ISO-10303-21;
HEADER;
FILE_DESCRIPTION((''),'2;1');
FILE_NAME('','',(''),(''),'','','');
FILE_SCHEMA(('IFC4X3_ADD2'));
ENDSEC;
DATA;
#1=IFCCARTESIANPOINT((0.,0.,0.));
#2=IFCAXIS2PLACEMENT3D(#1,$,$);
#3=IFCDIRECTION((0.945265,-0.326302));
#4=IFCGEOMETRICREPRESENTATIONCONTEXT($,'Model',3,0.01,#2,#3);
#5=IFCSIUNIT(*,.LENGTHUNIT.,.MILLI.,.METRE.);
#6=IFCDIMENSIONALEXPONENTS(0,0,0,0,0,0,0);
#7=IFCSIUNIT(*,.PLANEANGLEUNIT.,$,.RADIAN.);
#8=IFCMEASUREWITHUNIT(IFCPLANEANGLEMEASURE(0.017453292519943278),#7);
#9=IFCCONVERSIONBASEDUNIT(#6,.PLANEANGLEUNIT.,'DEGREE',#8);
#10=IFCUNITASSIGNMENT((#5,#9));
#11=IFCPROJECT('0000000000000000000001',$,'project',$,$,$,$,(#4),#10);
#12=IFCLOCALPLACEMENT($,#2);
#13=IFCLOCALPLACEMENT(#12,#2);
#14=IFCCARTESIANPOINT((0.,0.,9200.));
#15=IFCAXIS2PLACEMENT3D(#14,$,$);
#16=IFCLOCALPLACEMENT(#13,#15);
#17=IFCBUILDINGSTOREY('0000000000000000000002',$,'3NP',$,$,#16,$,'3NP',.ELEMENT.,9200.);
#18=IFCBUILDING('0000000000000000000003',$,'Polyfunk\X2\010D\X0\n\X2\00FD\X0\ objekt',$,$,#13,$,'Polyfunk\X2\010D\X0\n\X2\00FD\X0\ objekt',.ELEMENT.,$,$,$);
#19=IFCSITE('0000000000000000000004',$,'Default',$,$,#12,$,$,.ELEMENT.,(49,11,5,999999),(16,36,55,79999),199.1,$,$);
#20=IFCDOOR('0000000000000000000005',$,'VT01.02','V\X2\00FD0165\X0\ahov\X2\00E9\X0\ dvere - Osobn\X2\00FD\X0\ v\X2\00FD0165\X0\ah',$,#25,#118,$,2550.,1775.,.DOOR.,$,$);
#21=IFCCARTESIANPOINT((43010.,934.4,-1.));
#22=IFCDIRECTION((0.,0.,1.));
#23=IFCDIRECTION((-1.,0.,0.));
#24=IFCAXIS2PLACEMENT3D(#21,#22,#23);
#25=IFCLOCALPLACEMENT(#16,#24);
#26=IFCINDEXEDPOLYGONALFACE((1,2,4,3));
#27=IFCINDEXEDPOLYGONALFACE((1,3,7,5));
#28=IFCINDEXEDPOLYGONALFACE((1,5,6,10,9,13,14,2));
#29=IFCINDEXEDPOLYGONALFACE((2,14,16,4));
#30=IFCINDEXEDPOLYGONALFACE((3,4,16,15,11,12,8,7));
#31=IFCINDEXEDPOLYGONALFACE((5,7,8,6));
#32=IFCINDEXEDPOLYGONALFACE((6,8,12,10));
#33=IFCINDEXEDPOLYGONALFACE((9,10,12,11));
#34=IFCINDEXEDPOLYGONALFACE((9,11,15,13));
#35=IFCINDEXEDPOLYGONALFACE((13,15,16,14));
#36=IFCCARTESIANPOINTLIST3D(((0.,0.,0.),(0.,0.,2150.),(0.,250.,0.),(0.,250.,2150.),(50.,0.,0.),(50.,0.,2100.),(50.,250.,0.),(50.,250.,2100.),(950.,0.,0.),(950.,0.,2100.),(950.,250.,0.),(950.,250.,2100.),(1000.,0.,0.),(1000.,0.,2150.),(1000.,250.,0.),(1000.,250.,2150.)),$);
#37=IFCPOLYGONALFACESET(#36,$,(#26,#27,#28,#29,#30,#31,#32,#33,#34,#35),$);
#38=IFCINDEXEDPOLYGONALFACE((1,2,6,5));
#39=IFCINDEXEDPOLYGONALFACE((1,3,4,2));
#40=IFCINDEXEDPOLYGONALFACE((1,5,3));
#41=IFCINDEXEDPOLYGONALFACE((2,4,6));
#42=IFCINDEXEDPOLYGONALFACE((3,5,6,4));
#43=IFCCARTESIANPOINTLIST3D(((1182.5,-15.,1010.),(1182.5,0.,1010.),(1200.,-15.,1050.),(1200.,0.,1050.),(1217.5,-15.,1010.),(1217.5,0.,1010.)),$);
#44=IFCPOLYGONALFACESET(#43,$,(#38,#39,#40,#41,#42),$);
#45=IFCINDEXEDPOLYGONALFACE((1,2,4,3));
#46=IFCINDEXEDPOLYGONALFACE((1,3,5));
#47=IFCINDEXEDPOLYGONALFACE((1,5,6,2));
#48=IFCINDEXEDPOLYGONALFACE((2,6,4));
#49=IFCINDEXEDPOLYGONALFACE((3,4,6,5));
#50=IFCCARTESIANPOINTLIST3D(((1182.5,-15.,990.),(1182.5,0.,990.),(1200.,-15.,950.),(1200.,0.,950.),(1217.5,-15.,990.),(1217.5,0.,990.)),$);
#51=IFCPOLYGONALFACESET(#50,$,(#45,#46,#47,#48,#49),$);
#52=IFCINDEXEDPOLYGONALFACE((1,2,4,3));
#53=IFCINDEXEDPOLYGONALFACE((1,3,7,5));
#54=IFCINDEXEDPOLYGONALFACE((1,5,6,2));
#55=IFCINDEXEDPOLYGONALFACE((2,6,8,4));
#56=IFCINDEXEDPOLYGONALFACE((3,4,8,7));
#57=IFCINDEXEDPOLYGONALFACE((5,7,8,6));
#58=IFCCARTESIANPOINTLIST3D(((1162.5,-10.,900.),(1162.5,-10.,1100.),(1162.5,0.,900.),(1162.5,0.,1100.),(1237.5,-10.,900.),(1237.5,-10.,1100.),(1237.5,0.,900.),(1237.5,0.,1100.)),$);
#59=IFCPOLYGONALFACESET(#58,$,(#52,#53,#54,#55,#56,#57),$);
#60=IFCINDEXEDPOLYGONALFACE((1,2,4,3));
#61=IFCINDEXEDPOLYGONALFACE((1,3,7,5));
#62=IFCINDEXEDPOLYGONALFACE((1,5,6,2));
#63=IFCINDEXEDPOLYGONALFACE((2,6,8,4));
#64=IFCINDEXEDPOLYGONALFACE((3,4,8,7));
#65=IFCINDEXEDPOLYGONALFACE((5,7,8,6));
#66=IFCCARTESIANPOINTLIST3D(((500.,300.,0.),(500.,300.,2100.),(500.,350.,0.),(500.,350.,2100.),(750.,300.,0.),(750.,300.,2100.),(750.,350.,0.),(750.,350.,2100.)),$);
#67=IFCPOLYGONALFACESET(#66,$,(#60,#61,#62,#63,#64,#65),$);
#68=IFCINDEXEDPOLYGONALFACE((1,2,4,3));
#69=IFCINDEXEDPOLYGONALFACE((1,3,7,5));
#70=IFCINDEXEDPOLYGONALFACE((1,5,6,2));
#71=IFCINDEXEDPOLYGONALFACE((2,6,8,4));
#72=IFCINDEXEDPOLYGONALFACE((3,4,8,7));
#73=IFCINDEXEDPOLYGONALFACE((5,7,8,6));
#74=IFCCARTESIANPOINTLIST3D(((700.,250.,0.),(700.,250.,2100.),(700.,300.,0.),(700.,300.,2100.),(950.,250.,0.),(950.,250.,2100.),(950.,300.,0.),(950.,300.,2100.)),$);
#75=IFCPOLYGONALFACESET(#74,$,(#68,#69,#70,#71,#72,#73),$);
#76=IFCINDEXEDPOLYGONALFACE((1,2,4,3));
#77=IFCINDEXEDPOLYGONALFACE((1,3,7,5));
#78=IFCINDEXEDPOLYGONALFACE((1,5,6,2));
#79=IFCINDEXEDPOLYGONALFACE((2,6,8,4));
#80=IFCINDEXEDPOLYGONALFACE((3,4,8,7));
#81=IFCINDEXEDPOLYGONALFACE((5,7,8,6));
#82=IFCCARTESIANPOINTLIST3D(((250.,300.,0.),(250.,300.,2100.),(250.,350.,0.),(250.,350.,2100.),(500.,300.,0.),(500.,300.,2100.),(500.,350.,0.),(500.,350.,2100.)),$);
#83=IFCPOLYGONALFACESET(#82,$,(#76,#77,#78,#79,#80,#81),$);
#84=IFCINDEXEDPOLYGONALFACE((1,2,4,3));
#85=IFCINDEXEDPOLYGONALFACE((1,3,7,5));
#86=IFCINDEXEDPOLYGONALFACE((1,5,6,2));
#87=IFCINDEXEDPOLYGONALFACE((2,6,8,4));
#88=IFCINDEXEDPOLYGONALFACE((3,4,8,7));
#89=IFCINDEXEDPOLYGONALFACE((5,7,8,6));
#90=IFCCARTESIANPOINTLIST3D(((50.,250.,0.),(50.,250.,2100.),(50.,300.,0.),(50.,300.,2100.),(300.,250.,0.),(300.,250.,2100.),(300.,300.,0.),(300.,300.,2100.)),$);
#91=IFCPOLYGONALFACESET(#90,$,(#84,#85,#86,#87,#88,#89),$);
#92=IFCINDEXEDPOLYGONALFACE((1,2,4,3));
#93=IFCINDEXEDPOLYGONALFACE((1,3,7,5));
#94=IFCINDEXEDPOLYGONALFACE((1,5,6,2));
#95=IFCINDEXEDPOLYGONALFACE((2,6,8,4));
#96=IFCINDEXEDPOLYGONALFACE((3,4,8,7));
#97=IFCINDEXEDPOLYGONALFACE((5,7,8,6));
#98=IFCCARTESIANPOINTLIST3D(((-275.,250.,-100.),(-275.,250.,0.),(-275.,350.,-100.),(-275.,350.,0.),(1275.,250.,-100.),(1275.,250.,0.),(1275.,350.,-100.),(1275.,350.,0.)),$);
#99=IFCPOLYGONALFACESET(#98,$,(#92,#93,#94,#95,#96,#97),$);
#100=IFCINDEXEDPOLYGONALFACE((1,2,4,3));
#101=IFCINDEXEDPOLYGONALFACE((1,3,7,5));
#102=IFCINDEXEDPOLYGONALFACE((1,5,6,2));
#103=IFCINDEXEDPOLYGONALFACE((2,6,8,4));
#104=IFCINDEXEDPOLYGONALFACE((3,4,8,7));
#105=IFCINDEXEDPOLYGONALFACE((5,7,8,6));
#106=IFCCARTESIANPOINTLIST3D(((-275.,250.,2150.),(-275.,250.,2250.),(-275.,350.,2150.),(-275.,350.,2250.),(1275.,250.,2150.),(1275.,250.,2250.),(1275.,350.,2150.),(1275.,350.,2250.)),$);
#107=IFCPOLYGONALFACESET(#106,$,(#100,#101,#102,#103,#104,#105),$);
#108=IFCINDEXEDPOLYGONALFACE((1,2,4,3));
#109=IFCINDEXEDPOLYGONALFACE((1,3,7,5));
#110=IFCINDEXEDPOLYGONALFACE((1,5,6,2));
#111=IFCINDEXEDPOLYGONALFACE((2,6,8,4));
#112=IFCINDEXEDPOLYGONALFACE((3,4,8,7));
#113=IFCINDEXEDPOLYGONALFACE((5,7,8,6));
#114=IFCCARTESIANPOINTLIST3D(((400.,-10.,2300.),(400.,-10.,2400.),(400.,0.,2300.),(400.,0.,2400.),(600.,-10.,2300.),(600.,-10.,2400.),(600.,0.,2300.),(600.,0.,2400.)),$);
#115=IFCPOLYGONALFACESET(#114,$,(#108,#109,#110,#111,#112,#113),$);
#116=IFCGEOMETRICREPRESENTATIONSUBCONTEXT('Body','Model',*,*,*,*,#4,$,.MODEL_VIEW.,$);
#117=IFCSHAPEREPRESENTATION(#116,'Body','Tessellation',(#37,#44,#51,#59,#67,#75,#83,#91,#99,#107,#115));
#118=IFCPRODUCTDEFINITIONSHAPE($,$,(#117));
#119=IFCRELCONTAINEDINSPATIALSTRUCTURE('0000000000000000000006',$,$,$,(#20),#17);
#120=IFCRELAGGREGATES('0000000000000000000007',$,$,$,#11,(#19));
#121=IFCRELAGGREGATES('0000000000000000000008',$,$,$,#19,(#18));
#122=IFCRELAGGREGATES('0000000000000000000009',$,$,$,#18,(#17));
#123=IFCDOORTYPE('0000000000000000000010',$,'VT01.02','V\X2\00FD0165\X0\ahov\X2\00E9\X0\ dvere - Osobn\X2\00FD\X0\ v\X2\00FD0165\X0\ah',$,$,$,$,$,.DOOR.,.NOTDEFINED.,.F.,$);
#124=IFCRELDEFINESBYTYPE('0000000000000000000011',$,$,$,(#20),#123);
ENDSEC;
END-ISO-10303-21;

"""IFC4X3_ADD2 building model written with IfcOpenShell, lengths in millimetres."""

from ifc_helpers import new_model, entity, si_unit, converted_unit, direction, frame, frame_2d, origin, origin_2d_with_axis, place, context, subcontext, project, spatial, polyline, rectangle, outline, extrude, source, transform, mapped, type_object, type_shapes, element, save


model = new_model("IFC4X3_ADD2")

# Units and contexts
model_context = context("Model", 3, precision=0.01, world=origin(), true_north=direction((0.945265, -0.326302)))
body_context = subcontext(model_context, "Body", "Model", "MODEL_VIEW")
ifc_project = project(units=[si_unit("LENGTHUNIT", "METRE", prefix="MILLI"), converted_unit("PLANEANGLEUNIT", "DEGREE", entity("IfcPlaneAngleMeasure", 0.017453292519943278), si_unit("PLANEANGLEUNIT", "RADIAN"), dimensions=[0, 0, 0, 0, 0, 0, 0])], contexts=[model_context])

# Site, building, storey
site_placement = place(None, origin())
site = spatial("IfcSite", under=ifc_project, at=site_placement, Name="Default", CompositionType="ELEMENT", RefLatitude=(49, 11, 5, 999999), RefLongitude=(16, 36, 55, 79999), RefElevation=199.1)
building_placement = place(site_placement, origin())
building = spatial("IfcBuilding", under=site, at=building_placement, Name="Polyfunkčný objekt", LongName="Polyfunkčný objekt", CompositionType="ELEMENT")
storey_placement = place(building_placement, frame((0.0, 0.0, 9200.0)))
storey = spatial("IfcBuildingStorey", under=building, at=storey_placement, Name="3NP", LongName="3NP", CompositionType="ELEMENT", Elevation=9200.0)

# Door
door_type = type_object("IfcDoorType", Name="VT01.02", Description="Výťahové dvere - Osobný výťah", OperationType="NOTDEFINED", ParameterTakesPrecedence=False, PredefinedType="DOOR")
shared_shape_1 = source(origin(), body_context, "Body", "SweptSolid", [
    extrude(outline(polyline([(-1087.5, -500.0), (1062.5, -500.0), (1062.5, -450.0), (-1037.5, -450.0), (-1037.5, 450.0), (1062.5, 450.0), (1062.5, 500.0), (-1087.5, 500.0), (-1087.5, -500.0)])), frame((500.0, 0.0, 1062.5), z_axis=(0.0, 1.0, 0.0), x_axis=(0.0, 0.0, -1.0)), (0.0, 0.0, 1.0), 250.0),
    extrude(outline(polyline([(-24.4, -10.7), (19.2, -10.7), (5.2, 21.4), (-24.4, -10.7)])), frame((1200.0, -15.0, 1023.3), z_axis=(0.0, 1.0, 0.0), x_axis=(0.400819, 0.0, -0.916157)), (0.0, 0.0, 1.0), 15.0),
    extrude(outline(polyline([(-24.4, -10.7), (19.2, -10.7), (5.2, 21.4), (-24.4, -10.7)])), frame((1200.0, -15.0, 976.7), z_axis=(0.0, 1.0, 0.0), x_axis=(-0.400819, 0.0, 0.916157)), (0.0, 0.0, 1.0), 15.0),
    extrude(rectangle(XDim=10.0, YDim=75.0, at=frame_2d((0.0, 0.0), x_axis=(1.0, 0.0))), frame((1200.0, -5.0, 900.0), z_axis=(0.0, 0.0, 1.0), x_axis=(0.0, 1.0, 0.0)), (0.0, 0.0, 1.0), 200.0),
    extrude(rectangle(XDim=50.0, YDim=250.0, at=origin_2d_with_axis()), frame((625.0, 325.0, 0.0), z_axis=(0.0, 0.0, 1.0), x_axis=(0.0, -1.0, 0.0)), (0.0, 0.0, 1.0), 2100.0),
    extrude(rectangle(XDim=50.0, YDim=250.0, at=frame_2d((0.0, 0.0), x_axis=(1.0, 0.0))), frame((825.0, 275.0, 0.0), z_axis=(0.0, 0.0, 1.0), x_axis=(0.0, -1.0, 0.0)), (0.0, 0.0, 1.0), 2100.0),
    extrude(rectangle(XDim=250.0, YDim=50.0, at=frame_2d((0.0, 0.0), x_axis=(1.0, 0.0))), frame((375.0, 325.0, 0.0), z_axis=(0.0, 0.0, 1.0), x_axis=(-1.0, 0.0, 0.0)), (0.0, 0.0, 1.0), 2100.0),
    extrude(rectangle(XDim=250.0, YDim=50.0, at=frame_2d((0.0, 0.0), x_axis=(1.0, 0.0))), frame((175.0, 275.0, 0.0), z_axis=(0.0, 0.0, 1.0), x_axis=(-1.0, 0.0, 0.0)), (0.0, 0.0, 1.0), 2100.0),
    extrude(rectangle(XDim=1550.0, YDim=100.0, at=frame_2d((0.0, 0.0), x_axis=(1.0, 0.0))), frame((500.0, 300.0, -100.0), z_axis=(0.0, 0.0, 1.0), x_axis=(-1.0, 0.0, 0.0)), (0.0, 0.0, 1.0), 100.0),
    extrude(rectangle(XDim=1550.0, YDim=100.0, at=frame_2d((0.0, 0.0), x_axis=(1.0, 0.0))), frame((500.0, 300.0, 2150.0), z_axis=(0.0, 0.0, 1.0), x_axis=(-1.0, 0.0, 0.0)), (0.0, 0.0, 1.0), 100.0),
    extrude(rectangle(XDim=10.0, YDim=200.0, at=frame_2d((0.0, 0.0), x_axis=(1.0, 0.0))), frame((500.0, -5.0, 2300.0), z_axis=(0.0, 0.0, 1.0), x_axis=(0.0, 1.0, 0.0)), (0.0, 0.0, 1.0), 100.0),
])
type_shapes(door_type, [shared_shape_1])
door_placement = place(storey_placement, frame((43010.0, 934.4, -1.0), z_axis=(0.0, 0.0, 1.0), x_axis=(-1.0, 0.0, 0.0)))
element("IfcDoor", 1, at=door_placement, inside=storey, type_object=door_type, Name="VT01.02", Description="Výťahové dvere - Osobný výťah", OverallHeight=2550.0, OverallWidth=1775.0, PredefinedType="DOOR", context=body_context, shape_type="MappedRepresentation", body=[
    mapped(shared_shape_1, transform((0.0, 0.0, 0.0), scale=1.0)),
])

save(model, "model.ifc")
